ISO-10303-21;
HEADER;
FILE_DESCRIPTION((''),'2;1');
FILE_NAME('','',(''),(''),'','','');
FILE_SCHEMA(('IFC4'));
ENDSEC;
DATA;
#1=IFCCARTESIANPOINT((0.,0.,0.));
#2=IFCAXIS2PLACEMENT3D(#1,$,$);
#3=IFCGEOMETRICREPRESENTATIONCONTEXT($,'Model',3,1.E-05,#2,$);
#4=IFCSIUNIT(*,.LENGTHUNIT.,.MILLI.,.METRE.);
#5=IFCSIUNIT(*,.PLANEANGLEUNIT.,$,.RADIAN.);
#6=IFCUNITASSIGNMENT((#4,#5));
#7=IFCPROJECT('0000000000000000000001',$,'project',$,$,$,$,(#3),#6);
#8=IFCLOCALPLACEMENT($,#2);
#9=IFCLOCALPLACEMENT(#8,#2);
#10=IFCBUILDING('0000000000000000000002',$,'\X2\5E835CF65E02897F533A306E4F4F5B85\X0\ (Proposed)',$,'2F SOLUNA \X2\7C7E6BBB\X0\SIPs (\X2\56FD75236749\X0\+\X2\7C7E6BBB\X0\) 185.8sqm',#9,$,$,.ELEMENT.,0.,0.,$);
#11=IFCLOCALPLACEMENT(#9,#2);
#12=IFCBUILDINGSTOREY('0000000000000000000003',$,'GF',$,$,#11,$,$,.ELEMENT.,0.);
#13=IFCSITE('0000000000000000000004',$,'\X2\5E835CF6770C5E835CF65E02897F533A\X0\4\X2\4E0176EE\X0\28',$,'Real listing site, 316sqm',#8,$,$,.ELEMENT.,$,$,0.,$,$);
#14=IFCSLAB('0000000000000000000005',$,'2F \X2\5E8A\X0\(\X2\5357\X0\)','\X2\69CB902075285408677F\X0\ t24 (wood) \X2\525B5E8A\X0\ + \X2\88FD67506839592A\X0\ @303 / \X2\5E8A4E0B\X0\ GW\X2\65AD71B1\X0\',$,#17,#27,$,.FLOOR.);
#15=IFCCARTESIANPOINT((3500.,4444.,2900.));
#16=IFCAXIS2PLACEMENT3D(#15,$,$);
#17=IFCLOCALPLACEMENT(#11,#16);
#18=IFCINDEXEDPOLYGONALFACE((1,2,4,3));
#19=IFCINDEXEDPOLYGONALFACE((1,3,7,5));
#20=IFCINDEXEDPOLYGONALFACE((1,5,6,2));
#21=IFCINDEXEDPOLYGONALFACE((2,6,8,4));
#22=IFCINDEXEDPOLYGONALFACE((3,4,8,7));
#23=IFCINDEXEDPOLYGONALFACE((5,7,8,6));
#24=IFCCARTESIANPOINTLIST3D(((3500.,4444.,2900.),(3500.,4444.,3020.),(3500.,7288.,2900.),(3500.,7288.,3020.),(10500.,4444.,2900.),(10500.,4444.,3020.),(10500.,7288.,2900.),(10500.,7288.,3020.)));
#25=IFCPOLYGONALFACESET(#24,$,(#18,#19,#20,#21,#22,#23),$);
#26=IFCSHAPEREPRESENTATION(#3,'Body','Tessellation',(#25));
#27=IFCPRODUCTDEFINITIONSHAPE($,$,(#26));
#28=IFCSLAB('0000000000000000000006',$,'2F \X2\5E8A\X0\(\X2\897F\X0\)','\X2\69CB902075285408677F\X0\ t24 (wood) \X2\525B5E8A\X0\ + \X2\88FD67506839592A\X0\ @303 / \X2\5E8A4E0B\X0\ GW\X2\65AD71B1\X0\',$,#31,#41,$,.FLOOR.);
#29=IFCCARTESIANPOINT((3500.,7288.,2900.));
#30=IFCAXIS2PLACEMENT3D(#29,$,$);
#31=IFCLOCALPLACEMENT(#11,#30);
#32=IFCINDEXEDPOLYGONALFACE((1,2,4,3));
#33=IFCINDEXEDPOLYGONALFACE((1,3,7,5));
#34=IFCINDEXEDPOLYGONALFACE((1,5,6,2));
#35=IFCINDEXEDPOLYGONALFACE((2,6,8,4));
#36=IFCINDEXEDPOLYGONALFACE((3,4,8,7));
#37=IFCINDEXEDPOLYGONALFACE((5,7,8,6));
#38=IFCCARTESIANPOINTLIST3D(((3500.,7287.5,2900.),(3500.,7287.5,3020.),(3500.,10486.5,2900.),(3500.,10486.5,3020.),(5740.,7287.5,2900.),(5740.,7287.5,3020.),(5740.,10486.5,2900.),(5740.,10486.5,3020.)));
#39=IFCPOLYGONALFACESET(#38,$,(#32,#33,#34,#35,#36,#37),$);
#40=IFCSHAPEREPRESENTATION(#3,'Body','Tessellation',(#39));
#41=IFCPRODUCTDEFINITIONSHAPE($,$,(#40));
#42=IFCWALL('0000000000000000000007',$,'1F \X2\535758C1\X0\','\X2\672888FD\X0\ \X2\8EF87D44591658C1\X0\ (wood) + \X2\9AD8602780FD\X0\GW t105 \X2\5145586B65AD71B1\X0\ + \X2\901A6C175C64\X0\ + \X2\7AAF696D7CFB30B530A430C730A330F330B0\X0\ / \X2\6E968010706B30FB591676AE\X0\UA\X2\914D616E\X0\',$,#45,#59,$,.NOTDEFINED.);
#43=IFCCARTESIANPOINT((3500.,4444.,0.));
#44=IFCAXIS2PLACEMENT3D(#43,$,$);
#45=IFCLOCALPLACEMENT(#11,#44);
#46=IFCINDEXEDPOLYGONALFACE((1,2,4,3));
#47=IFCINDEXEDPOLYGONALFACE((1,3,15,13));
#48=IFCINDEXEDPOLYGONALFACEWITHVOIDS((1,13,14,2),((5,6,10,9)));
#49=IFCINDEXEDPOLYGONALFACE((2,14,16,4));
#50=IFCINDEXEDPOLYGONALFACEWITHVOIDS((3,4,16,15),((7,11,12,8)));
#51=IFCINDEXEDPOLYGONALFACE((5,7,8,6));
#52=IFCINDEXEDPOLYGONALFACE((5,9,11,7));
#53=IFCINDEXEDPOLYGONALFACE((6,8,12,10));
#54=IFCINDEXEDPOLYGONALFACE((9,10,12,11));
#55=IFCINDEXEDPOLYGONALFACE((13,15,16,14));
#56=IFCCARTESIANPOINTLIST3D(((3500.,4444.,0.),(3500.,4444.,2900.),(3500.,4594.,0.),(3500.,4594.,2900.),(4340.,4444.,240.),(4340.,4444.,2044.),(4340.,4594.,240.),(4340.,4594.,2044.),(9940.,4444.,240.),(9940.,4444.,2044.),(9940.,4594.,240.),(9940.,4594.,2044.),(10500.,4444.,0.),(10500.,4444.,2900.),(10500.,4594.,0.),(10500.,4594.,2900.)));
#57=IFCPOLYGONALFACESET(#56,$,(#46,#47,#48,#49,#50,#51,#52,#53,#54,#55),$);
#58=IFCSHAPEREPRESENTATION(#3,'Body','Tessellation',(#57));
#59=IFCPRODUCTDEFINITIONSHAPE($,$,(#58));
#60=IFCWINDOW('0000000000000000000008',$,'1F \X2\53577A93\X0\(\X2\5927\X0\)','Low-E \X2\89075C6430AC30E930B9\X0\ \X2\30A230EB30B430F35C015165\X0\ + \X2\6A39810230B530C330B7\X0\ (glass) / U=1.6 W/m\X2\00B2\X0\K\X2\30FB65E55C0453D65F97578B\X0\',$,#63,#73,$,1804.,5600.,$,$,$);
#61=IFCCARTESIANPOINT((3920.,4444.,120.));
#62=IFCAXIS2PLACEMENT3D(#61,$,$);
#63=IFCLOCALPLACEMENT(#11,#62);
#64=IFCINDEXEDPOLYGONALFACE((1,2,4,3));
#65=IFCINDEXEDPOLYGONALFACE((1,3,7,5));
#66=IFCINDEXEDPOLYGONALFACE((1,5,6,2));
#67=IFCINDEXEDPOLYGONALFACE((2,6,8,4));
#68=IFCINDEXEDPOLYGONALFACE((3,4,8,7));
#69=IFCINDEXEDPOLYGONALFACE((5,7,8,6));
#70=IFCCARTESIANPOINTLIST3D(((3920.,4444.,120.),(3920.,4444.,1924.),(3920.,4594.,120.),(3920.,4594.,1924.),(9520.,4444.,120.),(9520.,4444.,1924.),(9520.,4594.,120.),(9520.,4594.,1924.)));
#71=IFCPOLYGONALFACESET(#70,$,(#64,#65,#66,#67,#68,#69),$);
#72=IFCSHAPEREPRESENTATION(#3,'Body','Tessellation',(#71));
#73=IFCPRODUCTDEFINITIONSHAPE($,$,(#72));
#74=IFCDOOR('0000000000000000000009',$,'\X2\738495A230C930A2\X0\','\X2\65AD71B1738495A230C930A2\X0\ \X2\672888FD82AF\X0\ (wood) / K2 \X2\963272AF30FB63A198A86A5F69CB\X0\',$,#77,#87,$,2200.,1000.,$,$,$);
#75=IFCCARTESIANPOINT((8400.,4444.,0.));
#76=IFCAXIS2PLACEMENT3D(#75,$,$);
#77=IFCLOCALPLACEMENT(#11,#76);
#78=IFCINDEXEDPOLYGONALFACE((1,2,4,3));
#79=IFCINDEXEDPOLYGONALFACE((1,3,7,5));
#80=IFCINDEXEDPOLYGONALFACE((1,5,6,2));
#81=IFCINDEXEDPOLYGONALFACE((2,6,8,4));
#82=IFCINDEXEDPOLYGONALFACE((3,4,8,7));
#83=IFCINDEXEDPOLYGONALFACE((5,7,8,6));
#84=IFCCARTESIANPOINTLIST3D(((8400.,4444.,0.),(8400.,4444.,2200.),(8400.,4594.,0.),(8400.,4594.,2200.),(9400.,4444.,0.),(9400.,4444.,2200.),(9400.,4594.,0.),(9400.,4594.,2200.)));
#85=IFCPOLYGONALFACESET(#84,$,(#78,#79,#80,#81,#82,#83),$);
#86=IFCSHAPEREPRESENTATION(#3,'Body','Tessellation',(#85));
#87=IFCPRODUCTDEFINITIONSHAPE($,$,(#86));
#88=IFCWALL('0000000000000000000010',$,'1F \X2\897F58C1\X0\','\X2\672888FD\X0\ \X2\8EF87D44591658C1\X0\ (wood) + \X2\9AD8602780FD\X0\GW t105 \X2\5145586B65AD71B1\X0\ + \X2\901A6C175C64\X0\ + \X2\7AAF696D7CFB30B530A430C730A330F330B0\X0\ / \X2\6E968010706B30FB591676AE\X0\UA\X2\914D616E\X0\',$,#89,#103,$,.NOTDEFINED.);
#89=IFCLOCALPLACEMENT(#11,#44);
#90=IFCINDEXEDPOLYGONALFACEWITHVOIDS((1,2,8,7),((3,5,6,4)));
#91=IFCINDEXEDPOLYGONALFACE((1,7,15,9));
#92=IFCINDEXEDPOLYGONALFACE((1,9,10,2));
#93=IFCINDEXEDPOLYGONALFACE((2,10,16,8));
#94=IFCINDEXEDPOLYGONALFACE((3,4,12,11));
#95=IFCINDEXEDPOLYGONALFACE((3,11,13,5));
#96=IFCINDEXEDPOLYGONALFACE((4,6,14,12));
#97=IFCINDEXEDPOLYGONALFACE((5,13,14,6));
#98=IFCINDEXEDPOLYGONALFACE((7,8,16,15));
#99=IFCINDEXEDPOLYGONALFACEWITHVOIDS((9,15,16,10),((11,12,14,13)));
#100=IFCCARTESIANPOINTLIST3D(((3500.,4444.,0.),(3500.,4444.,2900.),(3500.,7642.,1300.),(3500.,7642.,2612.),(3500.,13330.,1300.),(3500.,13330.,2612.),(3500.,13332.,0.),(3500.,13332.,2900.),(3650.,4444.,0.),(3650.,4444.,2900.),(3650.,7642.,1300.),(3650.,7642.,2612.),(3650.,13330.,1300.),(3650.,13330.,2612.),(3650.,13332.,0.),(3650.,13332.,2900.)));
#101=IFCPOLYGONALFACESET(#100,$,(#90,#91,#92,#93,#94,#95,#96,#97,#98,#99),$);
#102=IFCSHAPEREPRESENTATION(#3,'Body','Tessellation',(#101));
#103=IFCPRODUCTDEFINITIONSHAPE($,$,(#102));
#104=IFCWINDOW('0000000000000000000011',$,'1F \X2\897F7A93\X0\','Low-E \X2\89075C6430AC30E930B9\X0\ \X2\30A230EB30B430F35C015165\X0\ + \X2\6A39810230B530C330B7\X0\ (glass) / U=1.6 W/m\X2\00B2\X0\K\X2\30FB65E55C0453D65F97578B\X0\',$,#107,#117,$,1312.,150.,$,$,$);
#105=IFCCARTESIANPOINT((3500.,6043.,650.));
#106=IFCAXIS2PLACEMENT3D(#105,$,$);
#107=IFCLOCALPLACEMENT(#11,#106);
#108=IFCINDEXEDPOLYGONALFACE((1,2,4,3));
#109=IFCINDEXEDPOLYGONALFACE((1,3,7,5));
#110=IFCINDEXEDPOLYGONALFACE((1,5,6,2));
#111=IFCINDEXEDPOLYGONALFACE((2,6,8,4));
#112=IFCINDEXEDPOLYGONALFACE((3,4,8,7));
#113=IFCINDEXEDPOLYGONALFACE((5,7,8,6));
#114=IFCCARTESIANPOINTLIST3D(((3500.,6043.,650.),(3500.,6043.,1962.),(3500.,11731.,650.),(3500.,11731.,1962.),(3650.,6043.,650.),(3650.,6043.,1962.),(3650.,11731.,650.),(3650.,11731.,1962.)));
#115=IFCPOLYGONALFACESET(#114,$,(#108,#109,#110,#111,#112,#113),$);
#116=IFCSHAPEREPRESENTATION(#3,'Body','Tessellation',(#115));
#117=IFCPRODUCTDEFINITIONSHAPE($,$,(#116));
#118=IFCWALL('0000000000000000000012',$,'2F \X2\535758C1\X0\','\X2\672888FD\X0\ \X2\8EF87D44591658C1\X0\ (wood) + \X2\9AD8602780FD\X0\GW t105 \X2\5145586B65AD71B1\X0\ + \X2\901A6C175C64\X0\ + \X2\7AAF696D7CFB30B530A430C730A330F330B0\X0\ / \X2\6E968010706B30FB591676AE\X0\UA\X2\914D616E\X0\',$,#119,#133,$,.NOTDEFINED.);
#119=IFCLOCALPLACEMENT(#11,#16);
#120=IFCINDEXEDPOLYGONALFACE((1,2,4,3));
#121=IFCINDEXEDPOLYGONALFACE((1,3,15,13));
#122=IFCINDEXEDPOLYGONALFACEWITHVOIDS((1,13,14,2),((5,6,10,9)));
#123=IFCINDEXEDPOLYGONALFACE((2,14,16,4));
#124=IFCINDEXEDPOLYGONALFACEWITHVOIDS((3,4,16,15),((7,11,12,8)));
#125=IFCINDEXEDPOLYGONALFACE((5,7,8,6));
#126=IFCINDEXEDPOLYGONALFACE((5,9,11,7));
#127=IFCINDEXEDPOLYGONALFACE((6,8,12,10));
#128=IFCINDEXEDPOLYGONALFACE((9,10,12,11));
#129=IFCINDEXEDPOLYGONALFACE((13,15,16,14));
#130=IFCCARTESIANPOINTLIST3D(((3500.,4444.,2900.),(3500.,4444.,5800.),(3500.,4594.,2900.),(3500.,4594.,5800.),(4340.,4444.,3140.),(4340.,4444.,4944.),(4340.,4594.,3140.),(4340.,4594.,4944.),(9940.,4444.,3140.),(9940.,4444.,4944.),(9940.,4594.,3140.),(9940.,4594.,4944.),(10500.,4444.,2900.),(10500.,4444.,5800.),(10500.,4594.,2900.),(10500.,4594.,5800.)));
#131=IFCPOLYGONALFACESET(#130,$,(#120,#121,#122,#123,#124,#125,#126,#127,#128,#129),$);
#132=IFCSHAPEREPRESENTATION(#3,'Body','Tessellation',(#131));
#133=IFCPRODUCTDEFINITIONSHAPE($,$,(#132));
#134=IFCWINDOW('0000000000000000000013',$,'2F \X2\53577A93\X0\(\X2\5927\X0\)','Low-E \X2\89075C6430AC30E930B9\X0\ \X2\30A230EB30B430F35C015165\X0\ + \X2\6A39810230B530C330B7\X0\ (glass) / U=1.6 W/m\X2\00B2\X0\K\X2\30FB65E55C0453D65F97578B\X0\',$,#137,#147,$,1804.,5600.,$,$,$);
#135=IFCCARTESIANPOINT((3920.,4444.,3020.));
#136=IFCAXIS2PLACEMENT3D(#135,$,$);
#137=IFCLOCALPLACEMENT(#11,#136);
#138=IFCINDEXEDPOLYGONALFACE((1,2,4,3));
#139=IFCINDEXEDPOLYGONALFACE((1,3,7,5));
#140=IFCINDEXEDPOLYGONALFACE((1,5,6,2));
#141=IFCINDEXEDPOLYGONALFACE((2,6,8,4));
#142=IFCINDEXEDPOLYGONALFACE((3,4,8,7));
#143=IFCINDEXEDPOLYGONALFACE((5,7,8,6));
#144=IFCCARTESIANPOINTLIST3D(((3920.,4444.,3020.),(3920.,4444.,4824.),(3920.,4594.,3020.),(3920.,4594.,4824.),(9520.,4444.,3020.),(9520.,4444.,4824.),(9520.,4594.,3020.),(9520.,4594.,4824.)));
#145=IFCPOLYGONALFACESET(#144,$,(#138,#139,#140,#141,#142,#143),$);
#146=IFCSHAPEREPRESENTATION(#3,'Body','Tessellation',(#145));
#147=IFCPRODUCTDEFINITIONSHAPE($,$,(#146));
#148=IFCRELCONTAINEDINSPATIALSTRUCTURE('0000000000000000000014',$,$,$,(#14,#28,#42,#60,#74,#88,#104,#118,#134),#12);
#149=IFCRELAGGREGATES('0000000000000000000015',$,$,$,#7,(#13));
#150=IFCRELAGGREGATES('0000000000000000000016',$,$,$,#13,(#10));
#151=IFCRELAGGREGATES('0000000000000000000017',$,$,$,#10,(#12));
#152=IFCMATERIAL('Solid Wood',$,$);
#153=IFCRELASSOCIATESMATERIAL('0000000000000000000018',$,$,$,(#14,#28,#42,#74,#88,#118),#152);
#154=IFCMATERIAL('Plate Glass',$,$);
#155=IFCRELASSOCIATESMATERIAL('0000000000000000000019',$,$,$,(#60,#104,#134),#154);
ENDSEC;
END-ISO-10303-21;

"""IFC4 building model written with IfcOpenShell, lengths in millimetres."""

from ifc_helpers import new_model, si_unit, frame, frame_2d, origin, place, context, project, spatial, rectangle, extrude, material, element, fill, save


model = new_model("IFC4")

# Units and contexts
model_context = context("Model", 3, precision=1e-05, world=origin())
ifc_project = project(units=[si_unit("LENGTHUNIT", "METRE", prefix="MILLI"), si_unit("PLANEANGLEUNIT", "RADIAN")], contexts=[model_context])

# Site, building, storey
site_placement = place(None, origin())
site = spatial("IfcSite", under=ifc_project, at=site_placement, Name="広島県広島市西区4丁目28", ObjectType="Real listing site, 316sqm", CompositionType="ELEMENT", RefElevation=0.0)
building_placement = place(site_placement, origin())
building = spatial("IfcBuilding", under=site, at=building_placement, Name="広島市西区の住宅 (Proposed)", ObjectType="2F SOLUNA 籾殻SIPs (国産杉+籾殻) 185.8sqm", CompositionType="ELEMENT", ElevationOfRefHeight=0.0, ElevationOfTerrain=0.0)
storey_placement = place(building_placement, origin())
storey = spatial("IfcBuildingStorey", under=building, at=storey_placement, Name="GF", CompositionType="ELEMENT", Elevation=0.0)

# Slabs
ifc_material_1 = material(Name="Solid Wood")
slab_1_placement = place(storey_placement, frame((3500.0, 4444.0, 2900.0)))
element("IfcSlab", 1, at=slab_1_placement, inside=storey, material=ifc_material_1, Name="2F 床(南)", Description="構造用合板 t24 (wood) 剛床 + 製材根太 @303 / 床下 GW断熱", PredefinedType="FLOOR", context=model_context, shape_type="SweptSolid", body=[
    extrude(rectangle(XDim=7000.0, YDim=2844.0, at=frame_2d((3500.0, 1422.0))), frame((3500.0, 4444.0, 2900.0)), (0.0, 0.0, 1.0), 120.0),
])
slab_2_placement = place(storey_placement, frame((3500.0, 7288.0, 2900.0)))
element("IfcSlab", 2, at=slab_2_placement, inside=storey, material=ifc_material_1, Name="2F 床(西)", Description="構造用合板 t24 (wood) 剛床 + 製材根太 @303 / 床下 GW断熱", PredefinedType="FLOOR", context=model_context, shape_type="SweptSolid", body=[
    extrude(rectangle(XDim=2240.0, YDim=3199.0, at=frame_2d((1120.0, 1599.0))), frame((3500.0, 7288.0, 2900.0)), (0.0, 0.0, 1.0), 120.0),
])

# Wall, openings, window, door
wall_1_placement = place(storey_placement, frame((3500.0, 4444.0, 0.0)))
wall_1 = element("IfcWall", 3, at=wall_1_placement, inside=storey, material=ifc_material_1, Name="1F 南壁", Description="木製 軸組外壁 (wood) + 高性能GW t105 充填断熱 + 通気層 + 窯業系サイディング / 準耐火・外皮UA配慮", PredefinedType="NOTDEFINED", context=model_context, shape_type="SweptSolid", body=[
    extrude(rectangle(XDim=7000.0, YDim=150.0, at=frame_2d((3500.0, 75.0))), frame((3500.0, 4444.0, 0.0)), (0.0, 0.0, 1.0), 2900.0),
])
opening_1_placement = place(storey_placement, frame((3920.0, 4444.0, 120.0)))
opening_1 = element("IfcOpeningElement", 4, at=opening_1_placement, cuts=wall_1, PredefinedType="NOTDEFINED", context=model_context, shape_type="SweptSolid", body=[
    extrude(rectangle(XDim=5600.0, YDim=150.0, at=frame_2d((2800.0, 75.0))), frame((3920.0, 4444.0, 120.0)), (0.0, 0.0, 1.0), 1804.0),
])
opening_2_placement = place(storey_placement, frame((8400.0, 4444.0, 0.0)))
opening_2 = element("IfcOpeningElement", 5, at=opening_2_placement, cuts=wall_1, PredefinedType="NOTDEFINED", context=model_context, shape_type="SweptSolid", body=[
    extrude(rectangle(XDim=1000.0, YDim=150.0, at=frame_2d((500.0, 75.0))), frame((8400.0, 4444.0, 0.0)), (0.0, 0.0, 1.0), 2200.0),
])
ifc_material_2 = material(Name="Plate Glass")
window_1_placement = place(storey_placement, frame((3920.0, 4444.0, 120.0)))
window_1 = element("IfcWindow", 6, at=window_1_placement, inside=storey, material=ifc_material_2, Name="1F 南窓(大)", Description="Low-E 複層ガラス アルゴン封入 + 樹脂サッシ (glass) / U=1.6 W/m²K・日射取得型", OverallHeight=1804.0, OverallWidth=5600.0, context=model_context, shape_type="SweptSolid", body=[
    extrude(rectangle(XDim=5600.0, YDim=150.0, at=frame_2d((2800.0, 75.0))), frame((3920.0, 4444.0, 120.0)), (0.0, 0.0, 1.0), 1804.0),
])
fill(opening_1, window_1)
door_placement = place(storey_placement, frame((8400.0, 4444.0, 0.0)))
door = element("IfcDoor", 7, at=door_placement, inside=storey, material=ifc_material_1, Name="玄関ドア", Description="断熱玄関ドア 木製芯 (wood) / K2 防犯・採風機構", OverallHeight=2200.0, OverallWidth=1000.0, context=model_context, shape_type="SweptSolid", body=[
    extrude(rectangle(XDim=1000.0, YDim=150.0, at=frame_2d((500.0, 75.0))), frame((8400.0, 4444.0, 0.0)), (0.0, 0.0, 1.0), 2200.0),
])
fill(opening_2, door)

# Walls, openings, windows
wall_2_placement = place(storey_placement, frame((3500.0, 4444.0, 0.0)))
wall_2 = element("IfcWall", 8, at=wall_2_placement, inside=storey, material=ifc_material_1, Name="1F 西壁", Description="木製 軸組外壁 (wood) + 高性能GW t105 充填断熱 + 通気層 + 窯業系サイディング / 準耐火・外皮UA配慮", PredefinedType="NOTDEFINED", context=model_context, shape_type="SweptSolid", body=[
    extrude(rectangle(XDim=150.0, YDim=8888.0, at=frame_2d((75.0, 4444.0))), frame((3500.0, 4444.0, 0.0)), (0.0, 0.0, 1.0), 2900.0),
])
opening_3_placement = place(storey_placement, frame((3500.0, 6043.0, 650.0)))
opening_3 = element("IfcOpeningElement", 9, at=opening_3_placement, cuts=wall_2, PredefinedType="NOTDEFINED", context=model_context, shape_type="SweptSolid", body=[
    extrude(rectangle(XDim=150.0, YDim=5688.0, at=frame_2d((75.0, 2844.0))), frame((3500.0, 6043.0, 650.0)), (0.0, 0.0, 1.0), 1312.0),
])
window_2_placement = place(storey_placement, frame((3500.0, 6043.0, 650.0)))
window_2 = element("IfcWindow", 10, at=window_2_placement, inside=storey, material=ifc_material_2, Name="1F 西窓", Description="Low-E 複層ガラス アルゴン封入 + 樹脂サッシ (glass) / U=1.6 W/m²K・日射取得型", OverallHeight=1312.0, OverallWidth=150.0, context=model_context, shape_type="SweptSolid", body=[
    extrude(rectangle(XDim=150.0, YDim=5688.0, at=frame_2d((75.0, 2844.0))), frame((3500.0, 6043.0, 650.0)), (0.0, 0.0, 1.0), 1312.0),
])
fill(opening_3, window_2)
wall_3_placement = place(storey_placement, frame((3500.0, 4444.0, 2900.0)))
wall_3 = element("IfcWall", 11, at=wall_3_placement, inside=storey, material=ifc_material_1, Name="2F 南壁", Description="木製 軸組外壁 (wood) + 高性能GW t105 充填断熱 + 通気層 + 窯業系サイディング / 準耐火・外皮UA配慮", PredefinedType="NOTDEFINED", context=model_context, shape_type="SweptSolid", body=[
    extrude(rectangle(XDim=7000.0, YDim=150.0, at=frame_2d((3500.0, 75.0))), frame((3500.0, 4444.0, 2900.0)), (0.0, 0.0, 1.0), 2900.0),
])
opening_4_placement = place(storey_placement, frame((3920.0, 4444.0, 3020.0)))
opening_4 = element("IfcOpeningElement", 12, at=opening_4_placement, cuts=wall_3, PredefinedType="NOTDEFINED", context=model_context, shape_type="SweptSolid", body=[
    extrude(rectangle(XDim=5600.0, YDim=150.0, at=frame_2d((2800.0, 75.0))), frame((3920.0, 4444.0, 3020.0)), (0.0, 0.0, 1.0), 1804.0),
])
window_3_placement = place(storey_placement, frame((3920.0, 4444.0, 3020.0)))
window_3 = element("IfcWindow", 13, at=window_3_placement, inside=storey, material=ifc_material_2, Name="2F 南窓(大)", Description="Low-E 複層ガラス アルゴン封入 + 樹脂サッシ (glass) / U=1.6 W/m²K・日射取得型", OverallHeight=1804.0, OverallWidth=5600.0, context=model_context, shape_type="SweptSolid", body=[
    extrude(rectangle(XDim=5600.0, YDim=150.0, at=frame_2d((2800.0, 75.0))), frame((3920.0, 4444.0, 3020.0)), (0.0, 0.0, 1.0), 1804.0),
])
fill(opening_4, window_3)

save(model, "model.ifc")
